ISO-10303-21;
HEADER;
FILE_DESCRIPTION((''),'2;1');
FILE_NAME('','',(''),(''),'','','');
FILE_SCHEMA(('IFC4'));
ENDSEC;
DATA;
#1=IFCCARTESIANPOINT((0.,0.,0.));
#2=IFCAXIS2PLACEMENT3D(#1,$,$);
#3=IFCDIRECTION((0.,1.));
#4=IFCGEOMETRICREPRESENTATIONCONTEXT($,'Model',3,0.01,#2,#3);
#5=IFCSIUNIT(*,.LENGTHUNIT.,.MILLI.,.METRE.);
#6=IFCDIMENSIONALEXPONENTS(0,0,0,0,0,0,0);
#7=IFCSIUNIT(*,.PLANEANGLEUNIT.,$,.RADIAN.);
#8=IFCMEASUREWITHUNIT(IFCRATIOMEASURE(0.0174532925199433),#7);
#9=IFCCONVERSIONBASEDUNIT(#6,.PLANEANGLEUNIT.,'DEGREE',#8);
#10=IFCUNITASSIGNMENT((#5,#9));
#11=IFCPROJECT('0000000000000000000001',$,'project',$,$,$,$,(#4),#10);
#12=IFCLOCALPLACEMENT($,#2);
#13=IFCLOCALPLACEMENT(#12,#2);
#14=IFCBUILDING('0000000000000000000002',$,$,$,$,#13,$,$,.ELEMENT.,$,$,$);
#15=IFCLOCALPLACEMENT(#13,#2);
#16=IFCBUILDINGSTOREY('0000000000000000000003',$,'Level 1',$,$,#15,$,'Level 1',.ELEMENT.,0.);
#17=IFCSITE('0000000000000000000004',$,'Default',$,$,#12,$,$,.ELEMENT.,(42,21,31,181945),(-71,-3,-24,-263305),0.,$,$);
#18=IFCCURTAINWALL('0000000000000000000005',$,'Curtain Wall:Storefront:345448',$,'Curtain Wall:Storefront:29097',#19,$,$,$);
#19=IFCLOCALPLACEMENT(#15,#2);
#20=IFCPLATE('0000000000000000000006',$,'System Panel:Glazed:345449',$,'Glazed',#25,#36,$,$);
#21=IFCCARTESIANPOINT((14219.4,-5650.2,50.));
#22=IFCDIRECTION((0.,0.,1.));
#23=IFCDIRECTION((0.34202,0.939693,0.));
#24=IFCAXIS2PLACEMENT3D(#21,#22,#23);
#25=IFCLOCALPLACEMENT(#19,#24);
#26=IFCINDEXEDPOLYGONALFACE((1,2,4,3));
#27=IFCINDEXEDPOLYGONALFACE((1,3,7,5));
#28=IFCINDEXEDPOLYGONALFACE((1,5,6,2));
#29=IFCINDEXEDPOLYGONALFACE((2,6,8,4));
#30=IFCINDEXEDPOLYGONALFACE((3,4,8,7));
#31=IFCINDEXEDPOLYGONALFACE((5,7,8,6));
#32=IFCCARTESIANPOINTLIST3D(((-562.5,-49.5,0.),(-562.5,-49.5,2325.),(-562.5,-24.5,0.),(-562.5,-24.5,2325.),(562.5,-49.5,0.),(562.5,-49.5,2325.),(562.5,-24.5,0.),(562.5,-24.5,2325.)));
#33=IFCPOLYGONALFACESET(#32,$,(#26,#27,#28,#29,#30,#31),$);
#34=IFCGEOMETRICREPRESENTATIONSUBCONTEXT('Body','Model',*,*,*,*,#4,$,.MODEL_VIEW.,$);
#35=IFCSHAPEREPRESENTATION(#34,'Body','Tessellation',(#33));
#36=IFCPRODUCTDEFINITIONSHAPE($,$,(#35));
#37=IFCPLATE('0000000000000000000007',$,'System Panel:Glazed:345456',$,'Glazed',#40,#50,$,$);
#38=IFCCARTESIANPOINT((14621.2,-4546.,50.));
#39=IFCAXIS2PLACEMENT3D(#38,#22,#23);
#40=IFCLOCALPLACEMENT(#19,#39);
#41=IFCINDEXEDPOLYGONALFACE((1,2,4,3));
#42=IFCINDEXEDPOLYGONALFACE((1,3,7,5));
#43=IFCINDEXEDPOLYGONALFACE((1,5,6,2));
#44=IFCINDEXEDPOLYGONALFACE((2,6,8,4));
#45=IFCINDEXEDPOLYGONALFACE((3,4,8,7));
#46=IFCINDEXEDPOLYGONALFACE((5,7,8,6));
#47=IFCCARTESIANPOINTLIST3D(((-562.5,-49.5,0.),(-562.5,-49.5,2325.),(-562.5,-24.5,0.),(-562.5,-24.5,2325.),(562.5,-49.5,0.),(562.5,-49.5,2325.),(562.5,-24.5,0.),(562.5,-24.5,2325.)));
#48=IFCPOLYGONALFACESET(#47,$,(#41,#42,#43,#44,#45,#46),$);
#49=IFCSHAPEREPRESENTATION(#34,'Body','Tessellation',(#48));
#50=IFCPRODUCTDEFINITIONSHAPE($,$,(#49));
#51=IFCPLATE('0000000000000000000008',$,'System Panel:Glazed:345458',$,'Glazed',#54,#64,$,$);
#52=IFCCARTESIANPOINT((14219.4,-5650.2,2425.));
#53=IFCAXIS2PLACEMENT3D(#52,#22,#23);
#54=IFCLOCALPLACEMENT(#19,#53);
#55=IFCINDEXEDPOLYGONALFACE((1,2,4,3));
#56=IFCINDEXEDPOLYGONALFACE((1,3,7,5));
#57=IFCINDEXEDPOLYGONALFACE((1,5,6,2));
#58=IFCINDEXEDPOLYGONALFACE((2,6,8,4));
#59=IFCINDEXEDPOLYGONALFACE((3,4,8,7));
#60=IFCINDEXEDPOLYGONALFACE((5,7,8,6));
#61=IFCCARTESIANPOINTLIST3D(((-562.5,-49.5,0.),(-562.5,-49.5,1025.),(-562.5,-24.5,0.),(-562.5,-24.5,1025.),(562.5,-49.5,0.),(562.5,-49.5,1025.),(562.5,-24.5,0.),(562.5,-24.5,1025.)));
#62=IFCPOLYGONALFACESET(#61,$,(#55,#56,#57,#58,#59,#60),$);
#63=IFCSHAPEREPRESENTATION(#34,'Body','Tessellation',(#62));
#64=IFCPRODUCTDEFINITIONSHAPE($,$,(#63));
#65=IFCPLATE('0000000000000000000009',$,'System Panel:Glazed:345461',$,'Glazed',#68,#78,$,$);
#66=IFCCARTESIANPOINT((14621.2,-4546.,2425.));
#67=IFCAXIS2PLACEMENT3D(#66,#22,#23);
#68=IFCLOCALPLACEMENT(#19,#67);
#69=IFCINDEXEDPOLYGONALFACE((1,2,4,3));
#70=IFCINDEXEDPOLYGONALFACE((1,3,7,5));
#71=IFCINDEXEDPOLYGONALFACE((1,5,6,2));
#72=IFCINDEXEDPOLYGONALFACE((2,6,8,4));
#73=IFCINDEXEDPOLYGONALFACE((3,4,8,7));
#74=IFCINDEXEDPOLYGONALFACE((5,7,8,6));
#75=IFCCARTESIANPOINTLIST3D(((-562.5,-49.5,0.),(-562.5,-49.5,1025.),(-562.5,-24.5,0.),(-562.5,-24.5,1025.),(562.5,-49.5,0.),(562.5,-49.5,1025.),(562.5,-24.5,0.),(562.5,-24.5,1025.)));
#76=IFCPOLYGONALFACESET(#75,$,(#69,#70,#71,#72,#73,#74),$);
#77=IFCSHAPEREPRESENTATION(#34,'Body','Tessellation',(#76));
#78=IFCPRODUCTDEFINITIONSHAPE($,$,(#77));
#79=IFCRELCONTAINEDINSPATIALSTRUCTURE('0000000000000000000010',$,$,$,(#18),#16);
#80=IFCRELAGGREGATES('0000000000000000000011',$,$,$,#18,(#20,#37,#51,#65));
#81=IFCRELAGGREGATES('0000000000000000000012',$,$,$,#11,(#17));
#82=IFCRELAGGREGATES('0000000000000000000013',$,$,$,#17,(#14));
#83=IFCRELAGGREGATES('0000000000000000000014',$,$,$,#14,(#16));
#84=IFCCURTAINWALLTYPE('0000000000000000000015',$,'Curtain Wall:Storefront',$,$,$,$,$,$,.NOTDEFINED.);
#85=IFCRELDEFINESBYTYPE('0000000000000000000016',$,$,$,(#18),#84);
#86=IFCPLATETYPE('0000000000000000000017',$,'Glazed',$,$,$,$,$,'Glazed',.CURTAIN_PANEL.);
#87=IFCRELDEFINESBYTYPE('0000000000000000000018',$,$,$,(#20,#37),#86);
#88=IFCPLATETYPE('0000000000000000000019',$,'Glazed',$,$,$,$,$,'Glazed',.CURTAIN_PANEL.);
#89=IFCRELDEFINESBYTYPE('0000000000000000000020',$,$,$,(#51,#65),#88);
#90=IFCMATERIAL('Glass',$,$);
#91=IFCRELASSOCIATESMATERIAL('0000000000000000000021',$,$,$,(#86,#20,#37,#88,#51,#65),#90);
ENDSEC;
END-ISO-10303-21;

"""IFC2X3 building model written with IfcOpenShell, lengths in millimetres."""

from ifc_helpers import new_model, entity, si_unit, converted_unit, direction, frame, frame_2d, origin, place, context, subcontext, project, spatial, rectangle, extrude, source, transform, mapped, material, type_object, type_shapes, element, aggregate, save


model = new_model("IFC2X3")

# Units and contexts
model_context = context("Model", 3, precision=0.01, world=origin(), true_north=direction((0.0, 1.0)))
body_context = subcontext(model_context, "Body", "Model", "MODEL_VIEW")
ifc_project = project(units=[si_unit("LENGTHUNIT", "METRE", prefix="MILLI"), converted_unit("PLANEANGLEUNIT", "DEGREE", entity("IfcRatioMeasure", 0.0174532925199433), si_unit("PLANEANGLEUNIT", "RADIAN"), dimensions=[0, 0, 0, 0, 0, 0, 0])], contexts=[model_context])

# Site, building, storey
site_placement = place(None, origin())
site = spatial("IfcSite", under=ifc_project, at=site_placement, Name="Default", CompositionType="ELEMENT", RefLatitude=(42, 21, 31, 181945), RefLongitude=(-71, -3, -24, -263305), RefElevation=0.0)
building_placement = place(site_placement, origin())
building = spatial("IfcBuilding", under=site, at=building_placement, CompositionType="ELEMENT")
storey_placement = place(building_placement, origin())
storey = spatial("IfcBuildingStorey", under=building, at=storey_placement, Name="Level 1", LongName="Level 1", CompositionType="ELEMENT", Elevation=0.0)

# Curtain wall, plates
curtain_wall_type = type_object("IfcCurtainWallType", Name="Curtain Wall:Storefront", PredefinedType="NOTDEFINED")
curtain_wall_placement = place(storey_placement, origin())
curtain_wall = element("IfcCurtainWall", 1, at=curtain_wall_placement, inside=storey, type_object=curtain_wall_type, Name="Curtain Wall:Storefront:345448", ObjectType="Curtain Wall:Storefront:29097")
ifc_material_1 = material(Name="Glass")
plate_type_1 = type_object("IfcPlateType", Name="Glazed", ElementType="Glazed", PredefinedType="CURTAIN_PANEL", material=ifc_material_1)
shared_shape_1 = source(origin(), body_context, "Body", "SweptSolid", [
    extrude(rectangle(XDim=25.0, YDim=1125.0, at=frame_2d((0.0, 0.0), x_axis=(1.0, 0.0))), frame((0.0, -37.0, 0.0), z_axis=(0.0, 0.0, 1.0), x_axis=(0.0, 1.0, 0.0)), (0.0, 0.0, 1.0), 2325.0),
])
type_shapes(plate_type_1, [shared_shape_1])
plate_1_placement = place(curtain_wall_placement, frame((14219.4, -5650.2, 50.0), z_axis=(0.0, 0.0, 1.0), x_axis=(0.34202, 0.939693, 0.0)))
plate_1 = element("IfcPlate", 2, at=plate_1_placement, type_object=plate_type_1, material=ifc_material_1, Name="System Panel:Glazed:345449", ObjectType="Glazed", context=body_context, shape_type="MappedRepresentation", body=[
    mapped(shared_shape_1, transform((0.0, 0.0, 0.0), scale=1.0)),
])
plate_2_placement = place(curtain_wall_placement, frame((14621.2, -4546.0, 50.0), z_axis=(0.0, 0.0, 1.0), x_axis=(0.34202, 0.939693, 0.0)))
plate_2 = element("IfcPlate", 3, at=plate_2_placement, type_object=plate_type_1, material=ifc_material_1, Name="System Panel:Glazed:345456", ObjectType="Glazed", context=body_context, shape_type="MappedRepresentation", body=[
    mapped(shared_shape_1, transform((0.0, 0.0, 0.0), scale=1.0)),
])
plate_type_2 = type_object("IfcPlateType", Name="Glazed", ElementType="Glazed", PredefinedType="CURTAIN_PANEL", material=ifc_material_1)
shared_shape_2 = source(origin(), body_context, "Body", "SweptSolid", [
    extrude(rectangle(XDim=25.0, YDim=1125.0, at=frame_2d((0.0, 0.0), x_axis=(1.0, 0.0))), frame((0.0, -37.0, 0.0), z_axis=(0.0, 0.0, 1.0), x_axis=(0.0, 1.0, 0.0)), (0.0, 0.0, 1.0), 1025.0),
])
type_shapes(plate_type_2, [shared_shape_2])
plate_3_placement = place(curtain_wall_placement, frame((14219.4, -5650.2, 2425.0), z_axis=(0.0, 0.0, 1.0), x_axis=(0.34202, 0.939693, 0.0)))
plate_3 = element("IfcPlate", 4, at=plate_3_placement, type_object=plate_type_2, material=ifc_material_1, Name="System Panel:Glazed:345458", ObjectType="Glazed", context=body_context, shape_type="MappedRepresentation", body=[
    mapped(shared_shape_2, transform((0.0, 0.0, 0.0), scale=1.0)),
])
plate_4_placement = place(curtain_wall_placement, frame((14621.2, -4546.0, 2425.0), z_axis=(0.0, 0.0, 1.0), x_axis=(0.34202, 0.939693, 0.0)))
plate_4 = element("IfcPlate", 5, at=plate_4_placement, type_object=plate_type_2, material=ifc_material_1, Name="System Panel:Glazed:345461", ObjectType="Glazed", context=body_context, shape_type="MappedRepresentation", body=[
    mapped(shared_shape_2, transform((0.0, 0.0, 0.0), scale=1.0)),
])
aggregate(curtain_wall, [plate_1, plate_2, plate_3, plate_4])

save(model, "model.ifc")
